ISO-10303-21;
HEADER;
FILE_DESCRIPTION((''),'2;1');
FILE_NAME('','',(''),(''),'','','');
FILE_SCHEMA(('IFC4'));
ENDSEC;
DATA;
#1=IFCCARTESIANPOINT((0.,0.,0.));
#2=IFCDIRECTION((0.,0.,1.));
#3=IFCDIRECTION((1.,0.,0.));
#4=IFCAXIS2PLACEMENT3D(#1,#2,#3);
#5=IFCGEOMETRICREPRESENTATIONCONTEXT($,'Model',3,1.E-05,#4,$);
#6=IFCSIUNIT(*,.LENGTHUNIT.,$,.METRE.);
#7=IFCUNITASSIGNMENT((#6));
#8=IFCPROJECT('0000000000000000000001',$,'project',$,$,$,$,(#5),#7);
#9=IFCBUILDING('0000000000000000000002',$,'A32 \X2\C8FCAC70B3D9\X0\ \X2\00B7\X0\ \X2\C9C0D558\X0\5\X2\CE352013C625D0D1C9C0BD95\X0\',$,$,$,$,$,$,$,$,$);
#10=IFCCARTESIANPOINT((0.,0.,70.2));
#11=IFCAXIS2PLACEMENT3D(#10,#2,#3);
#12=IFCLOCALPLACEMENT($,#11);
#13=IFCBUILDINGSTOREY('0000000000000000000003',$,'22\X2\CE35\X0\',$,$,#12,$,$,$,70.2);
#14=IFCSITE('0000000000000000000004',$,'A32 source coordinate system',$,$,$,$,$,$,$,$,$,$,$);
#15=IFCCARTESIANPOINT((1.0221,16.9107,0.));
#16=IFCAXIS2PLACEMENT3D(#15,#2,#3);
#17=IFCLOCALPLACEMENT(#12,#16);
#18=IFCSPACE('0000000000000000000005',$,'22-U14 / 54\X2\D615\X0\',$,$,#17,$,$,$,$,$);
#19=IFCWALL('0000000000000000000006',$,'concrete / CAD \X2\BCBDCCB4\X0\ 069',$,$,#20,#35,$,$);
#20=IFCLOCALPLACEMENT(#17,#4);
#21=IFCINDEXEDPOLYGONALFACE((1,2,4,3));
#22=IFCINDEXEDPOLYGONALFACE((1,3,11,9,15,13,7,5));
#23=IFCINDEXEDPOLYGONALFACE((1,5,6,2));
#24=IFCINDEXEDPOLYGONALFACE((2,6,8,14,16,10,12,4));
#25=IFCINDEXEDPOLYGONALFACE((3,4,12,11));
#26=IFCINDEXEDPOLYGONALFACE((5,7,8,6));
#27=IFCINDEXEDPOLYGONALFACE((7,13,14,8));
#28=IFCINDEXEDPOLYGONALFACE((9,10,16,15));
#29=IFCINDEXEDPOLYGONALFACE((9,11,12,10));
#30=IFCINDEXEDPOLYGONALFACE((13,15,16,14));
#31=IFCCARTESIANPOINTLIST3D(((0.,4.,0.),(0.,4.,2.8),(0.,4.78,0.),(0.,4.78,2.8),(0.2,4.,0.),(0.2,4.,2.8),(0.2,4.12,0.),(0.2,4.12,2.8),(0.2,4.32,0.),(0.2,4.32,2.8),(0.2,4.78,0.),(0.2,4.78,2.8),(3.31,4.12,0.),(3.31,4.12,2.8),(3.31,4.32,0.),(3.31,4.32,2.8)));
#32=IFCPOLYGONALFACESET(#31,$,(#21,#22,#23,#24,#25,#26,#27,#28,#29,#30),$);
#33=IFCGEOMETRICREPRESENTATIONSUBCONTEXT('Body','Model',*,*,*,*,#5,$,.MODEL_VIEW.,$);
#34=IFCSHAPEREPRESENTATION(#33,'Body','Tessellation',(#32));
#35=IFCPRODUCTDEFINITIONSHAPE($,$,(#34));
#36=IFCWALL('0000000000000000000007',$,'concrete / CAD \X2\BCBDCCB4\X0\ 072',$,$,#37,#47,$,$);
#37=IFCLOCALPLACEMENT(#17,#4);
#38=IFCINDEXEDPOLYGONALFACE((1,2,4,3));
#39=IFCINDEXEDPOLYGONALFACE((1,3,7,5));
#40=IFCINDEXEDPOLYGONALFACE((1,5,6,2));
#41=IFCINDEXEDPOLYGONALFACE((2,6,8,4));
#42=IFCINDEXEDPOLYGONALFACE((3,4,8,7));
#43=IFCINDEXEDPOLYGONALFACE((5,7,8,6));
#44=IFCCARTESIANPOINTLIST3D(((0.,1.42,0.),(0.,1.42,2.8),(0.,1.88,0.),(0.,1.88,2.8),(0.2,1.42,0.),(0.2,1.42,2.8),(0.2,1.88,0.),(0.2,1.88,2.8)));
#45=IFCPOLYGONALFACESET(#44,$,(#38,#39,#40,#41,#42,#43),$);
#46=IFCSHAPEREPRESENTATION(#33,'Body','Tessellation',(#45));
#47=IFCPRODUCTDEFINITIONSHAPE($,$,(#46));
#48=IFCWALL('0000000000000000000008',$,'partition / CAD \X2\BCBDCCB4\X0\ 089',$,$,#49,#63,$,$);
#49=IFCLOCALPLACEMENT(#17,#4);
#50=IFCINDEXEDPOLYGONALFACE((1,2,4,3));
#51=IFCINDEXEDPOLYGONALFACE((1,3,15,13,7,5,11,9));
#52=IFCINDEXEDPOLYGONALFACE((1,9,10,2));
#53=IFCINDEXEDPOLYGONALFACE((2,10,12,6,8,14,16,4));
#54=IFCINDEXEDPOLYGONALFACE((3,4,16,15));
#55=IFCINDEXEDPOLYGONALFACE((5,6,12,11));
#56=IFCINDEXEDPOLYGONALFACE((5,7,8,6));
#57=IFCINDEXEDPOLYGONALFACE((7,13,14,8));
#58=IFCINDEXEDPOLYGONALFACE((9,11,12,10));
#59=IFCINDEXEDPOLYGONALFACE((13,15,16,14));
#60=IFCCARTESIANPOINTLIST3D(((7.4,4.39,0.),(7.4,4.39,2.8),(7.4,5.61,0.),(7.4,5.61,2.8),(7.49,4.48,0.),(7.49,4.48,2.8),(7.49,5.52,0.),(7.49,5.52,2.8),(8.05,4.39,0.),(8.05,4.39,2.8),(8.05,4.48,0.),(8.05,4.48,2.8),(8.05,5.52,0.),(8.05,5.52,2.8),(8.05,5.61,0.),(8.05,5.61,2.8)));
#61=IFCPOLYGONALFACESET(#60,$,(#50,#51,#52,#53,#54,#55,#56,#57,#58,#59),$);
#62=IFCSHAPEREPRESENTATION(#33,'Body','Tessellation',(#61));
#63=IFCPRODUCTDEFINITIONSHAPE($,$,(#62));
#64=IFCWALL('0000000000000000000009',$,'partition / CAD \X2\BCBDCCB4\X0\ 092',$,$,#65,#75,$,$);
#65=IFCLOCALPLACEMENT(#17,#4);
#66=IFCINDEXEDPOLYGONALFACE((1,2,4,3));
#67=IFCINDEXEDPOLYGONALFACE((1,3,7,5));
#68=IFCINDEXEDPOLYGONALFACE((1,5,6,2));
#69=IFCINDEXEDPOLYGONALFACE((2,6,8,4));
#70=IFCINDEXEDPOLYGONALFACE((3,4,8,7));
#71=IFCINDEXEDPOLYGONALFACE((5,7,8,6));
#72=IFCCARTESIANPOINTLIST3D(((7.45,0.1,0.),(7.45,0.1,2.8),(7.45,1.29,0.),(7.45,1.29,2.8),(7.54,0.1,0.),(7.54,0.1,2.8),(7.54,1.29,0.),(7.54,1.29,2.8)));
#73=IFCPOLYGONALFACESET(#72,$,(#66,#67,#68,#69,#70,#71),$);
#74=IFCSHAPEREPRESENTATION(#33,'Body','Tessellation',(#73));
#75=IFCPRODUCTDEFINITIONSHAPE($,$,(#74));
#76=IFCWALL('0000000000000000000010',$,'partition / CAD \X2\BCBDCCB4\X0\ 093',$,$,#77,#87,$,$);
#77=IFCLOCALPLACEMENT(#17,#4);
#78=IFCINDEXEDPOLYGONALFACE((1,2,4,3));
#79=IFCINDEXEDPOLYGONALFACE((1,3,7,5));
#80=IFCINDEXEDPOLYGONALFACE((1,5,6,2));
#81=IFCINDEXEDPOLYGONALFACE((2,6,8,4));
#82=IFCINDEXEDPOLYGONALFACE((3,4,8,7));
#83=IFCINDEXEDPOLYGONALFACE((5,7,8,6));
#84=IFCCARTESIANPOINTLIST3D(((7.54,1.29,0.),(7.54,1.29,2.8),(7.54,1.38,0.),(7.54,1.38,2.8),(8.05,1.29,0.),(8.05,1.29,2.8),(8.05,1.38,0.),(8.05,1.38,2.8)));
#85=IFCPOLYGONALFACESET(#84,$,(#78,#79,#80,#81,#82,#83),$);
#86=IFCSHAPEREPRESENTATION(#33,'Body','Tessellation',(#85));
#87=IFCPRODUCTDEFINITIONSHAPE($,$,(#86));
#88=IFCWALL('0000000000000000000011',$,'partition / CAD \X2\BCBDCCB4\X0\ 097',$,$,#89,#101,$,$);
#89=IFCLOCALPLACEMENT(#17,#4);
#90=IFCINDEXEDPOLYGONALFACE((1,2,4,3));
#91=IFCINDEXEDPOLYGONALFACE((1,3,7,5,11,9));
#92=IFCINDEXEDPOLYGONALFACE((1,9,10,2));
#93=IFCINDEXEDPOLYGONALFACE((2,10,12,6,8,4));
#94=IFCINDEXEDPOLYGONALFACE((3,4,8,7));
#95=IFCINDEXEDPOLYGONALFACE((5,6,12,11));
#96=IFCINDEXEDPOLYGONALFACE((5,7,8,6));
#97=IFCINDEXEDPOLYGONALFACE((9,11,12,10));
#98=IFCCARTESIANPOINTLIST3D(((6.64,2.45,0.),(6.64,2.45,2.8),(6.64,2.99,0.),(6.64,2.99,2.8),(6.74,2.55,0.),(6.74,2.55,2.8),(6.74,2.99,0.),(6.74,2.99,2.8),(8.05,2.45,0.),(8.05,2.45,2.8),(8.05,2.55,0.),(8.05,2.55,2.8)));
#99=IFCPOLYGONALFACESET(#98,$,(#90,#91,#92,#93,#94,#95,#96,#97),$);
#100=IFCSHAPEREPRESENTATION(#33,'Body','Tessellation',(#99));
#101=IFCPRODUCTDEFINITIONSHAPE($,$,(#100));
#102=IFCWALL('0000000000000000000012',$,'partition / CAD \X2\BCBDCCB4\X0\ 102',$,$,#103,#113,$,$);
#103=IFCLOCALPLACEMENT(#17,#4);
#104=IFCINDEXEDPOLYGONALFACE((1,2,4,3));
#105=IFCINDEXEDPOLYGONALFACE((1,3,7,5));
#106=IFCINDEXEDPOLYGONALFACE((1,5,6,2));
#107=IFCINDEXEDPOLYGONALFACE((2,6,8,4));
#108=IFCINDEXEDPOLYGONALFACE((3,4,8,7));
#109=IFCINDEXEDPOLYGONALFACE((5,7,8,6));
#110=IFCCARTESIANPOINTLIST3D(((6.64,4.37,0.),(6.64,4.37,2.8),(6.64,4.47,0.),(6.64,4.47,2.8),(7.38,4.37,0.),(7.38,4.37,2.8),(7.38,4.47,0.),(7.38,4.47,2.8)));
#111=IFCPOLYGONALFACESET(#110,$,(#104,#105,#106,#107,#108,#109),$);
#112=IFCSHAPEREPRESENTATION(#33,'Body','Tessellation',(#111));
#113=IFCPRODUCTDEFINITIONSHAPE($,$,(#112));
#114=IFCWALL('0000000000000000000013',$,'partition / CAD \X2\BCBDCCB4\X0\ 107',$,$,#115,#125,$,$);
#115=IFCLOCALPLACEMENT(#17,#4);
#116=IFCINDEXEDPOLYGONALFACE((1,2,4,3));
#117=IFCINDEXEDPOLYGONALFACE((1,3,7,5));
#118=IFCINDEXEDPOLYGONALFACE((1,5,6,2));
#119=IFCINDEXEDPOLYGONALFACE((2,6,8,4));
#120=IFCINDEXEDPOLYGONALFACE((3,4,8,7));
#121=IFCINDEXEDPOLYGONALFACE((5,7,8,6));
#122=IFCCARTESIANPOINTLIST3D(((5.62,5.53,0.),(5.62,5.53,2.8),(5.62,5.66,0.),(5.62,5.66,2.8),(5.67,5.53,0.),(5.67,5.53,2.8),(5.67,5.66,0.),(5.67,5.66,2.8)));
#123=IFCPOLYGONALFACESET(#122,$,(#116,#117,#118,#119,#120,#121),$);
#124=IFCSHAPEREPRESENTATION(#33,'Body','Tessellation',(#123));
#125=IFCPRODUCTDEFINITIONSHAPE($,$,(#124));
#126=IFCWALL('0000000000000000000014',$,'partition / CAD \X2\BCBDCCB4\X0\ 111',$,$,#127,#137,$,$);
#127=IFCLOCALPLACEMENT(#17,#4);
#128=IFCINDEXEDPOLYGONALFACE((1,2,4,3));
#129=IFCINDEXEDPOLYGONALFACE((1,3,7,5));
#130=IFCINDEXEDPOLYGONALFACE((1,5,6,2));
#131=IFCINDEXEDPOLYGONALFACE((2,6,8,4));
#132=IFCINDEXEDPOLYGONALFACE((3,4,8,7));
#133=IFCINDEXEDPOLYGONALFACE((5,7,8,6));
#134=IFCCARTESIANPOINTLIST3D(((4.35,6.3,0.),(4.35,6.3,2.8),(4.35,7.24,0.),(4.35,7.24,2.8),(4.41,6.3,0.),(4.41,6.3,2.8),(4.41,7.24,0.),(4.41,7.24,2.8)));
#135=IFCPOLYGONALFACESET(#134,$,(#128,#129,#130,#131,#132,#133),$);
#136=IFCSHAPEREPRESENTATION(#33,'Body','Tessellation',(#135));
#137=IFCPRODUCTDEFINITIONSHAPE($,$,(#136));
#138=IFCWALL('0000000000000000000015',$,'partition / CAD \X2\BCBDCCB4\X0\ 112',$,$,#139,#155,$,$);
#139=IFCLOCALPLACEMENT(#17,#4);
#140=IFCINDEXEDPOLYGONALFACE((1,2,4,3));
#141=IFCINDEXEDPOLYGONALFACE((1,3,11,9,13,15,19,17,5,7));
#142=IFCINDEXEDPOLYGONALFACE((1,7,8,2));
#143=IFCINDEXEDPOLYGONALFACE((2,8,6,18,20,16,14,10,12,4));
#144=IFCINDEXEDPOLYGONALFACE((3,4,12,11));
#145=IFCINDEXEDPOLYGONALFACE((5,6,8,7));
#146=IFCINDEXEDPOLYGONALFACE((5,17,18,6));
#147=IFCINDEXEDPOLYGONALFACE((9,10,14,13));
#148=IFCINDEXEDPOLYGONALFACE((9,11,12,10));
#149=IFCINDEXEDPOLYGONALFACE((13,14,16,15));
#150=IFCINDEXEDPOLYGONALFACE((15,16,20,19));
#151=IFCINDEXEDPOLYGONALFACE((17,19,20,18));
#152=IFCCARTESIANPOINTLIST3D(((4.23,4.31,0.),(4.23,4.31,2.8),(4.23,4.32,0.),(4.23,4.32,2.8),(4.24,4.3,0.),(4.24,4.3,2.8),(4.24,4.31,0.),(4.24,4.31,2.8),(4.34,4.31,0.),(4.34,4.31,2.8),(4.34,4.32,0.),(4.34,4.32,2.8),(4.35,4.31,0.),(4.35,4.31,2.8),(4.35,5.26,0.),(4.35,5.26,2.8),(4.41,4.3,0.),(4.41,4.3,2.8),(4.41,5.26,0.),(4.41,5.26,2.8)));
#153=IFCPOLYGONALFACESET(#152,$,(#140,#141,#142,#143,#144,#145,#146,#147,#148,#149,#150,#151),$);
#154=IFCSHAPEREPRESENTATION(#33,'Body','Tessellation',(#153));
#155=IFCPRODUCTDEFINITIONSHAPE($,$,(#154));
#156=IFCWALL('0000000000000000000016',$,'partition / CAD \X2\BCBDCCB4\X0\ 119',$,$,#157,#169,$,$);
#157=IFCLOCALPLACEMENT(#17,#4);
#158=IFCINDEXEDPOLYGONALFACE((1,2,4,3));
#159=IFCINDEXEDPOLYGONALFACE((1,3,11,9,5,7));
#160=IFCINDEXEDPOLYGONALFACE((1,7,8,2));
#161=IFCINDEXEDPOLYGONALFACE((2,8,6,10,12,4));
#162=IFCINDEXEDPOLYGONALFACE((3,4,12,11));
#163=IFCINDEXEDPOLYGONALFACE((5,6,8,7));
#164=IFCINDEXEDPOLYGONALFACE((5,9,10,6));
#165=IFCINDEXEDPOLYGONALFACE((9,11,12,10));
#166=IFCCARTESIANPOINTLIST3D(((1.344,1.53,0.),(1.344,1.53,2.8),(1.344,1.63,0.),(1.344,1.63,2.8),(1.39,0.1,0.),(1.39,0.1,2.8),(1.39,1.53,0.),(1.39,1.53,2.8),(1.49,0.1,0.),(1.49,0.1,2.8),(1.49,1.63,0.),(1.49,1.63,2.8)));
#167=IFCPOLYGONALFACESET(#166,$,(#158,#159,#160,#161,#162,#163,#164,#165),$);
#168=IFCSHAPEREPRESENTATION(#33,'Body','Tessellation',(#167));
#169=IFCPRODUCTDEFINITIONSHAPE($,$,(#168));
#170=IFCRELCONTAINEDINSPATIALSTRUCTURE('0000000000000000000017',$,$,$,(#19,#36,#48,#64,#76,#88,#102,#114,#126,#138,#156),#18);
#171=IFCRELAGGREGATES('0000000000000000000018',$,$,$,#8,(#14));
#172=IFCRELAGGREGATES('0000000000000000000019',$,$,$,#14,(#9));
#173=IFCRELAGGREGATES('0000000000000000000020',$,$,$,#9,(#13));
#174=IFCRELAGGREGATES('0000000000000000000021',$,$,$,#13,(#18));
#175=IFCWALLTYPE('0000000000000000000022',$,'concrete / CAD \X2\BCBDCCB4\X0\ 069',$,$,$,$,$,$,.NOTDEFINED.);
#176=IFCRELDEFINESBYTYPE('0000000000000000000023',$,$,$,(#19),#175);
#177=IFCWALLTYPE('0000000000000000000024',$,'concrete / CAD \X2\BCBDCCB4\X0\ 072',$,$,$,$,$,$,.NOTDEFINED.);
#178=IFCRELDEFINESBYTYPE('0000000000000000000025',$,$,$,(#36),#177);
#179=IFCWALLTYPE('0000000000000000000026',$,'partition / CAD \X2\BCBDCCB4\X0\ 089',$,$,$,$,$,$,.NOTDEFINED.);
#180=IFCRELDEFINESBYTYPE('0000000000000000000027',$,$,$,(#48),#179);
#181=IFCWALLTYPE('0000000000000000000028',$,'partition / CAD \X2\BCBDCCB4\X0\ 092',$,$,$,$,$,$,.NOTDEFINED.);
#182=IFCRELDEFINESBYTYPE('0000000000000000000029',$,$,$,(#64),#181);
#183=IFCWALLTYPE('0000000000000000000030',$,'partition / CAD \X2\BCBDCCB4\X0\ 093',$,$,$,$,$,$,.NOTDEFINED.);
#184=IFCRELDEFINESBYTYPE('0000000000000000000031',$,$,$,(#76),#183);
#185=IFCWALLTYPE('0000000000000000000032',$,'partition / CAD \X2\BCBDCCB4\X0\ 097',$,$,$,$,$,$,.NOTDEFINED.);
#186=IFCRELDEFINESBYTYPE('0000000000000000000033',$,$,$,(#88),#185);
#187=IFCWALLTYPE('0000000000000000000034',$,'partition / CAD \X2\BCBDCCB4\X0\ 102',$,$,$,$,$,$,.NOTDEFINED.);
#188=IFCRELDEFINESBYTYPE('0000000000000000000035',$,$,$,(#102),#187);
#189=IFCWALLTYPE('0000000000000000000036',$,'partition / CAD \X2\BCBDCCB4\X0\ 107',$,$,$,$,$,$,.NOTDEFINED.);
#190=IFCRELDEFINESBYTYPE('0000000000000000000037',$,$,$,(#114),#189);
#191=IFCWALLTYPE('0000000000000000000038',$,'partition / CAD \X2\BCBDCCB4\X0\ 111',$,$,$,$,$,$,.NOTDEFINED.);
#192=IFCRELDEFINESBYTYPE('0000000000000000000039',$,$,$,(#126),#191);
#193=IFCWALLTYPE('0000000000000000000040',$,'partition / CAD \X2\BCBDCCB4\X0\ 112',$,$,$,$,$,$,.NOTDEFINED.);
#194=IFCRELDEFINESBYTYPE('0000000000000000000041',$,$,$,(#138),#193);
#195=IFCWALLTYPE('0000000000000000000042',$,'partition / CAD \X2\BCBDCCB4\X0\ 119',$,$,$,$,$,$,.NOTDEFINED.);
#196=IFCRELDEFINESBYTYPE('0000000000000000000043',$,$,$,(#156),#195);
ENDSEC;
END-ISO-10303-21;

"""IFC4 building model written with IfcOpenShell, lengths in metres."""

from ifc_helpers import new_model, si_unit, frame, origin, origin_with_axes, place, context, subcontext, project, spatial, polyline, outline, extrude, source, transform, mapped, type_object, type_shapes, element, save


model = new_model("IFC4")

# Units and contexts
model_context = context("Model", 3, precision=1e-05, world=origin_with_axes())
body_context = subcontext(model_context, "Body", "Model", "MODEL_VIEW")
ifc_project = project(units=[si_unit("LENGTHUNIT", "METRE")], contexts=[model_context])

# Site, building, storey, space
site = spatial("IfcSite", under=ifc_project, Name="A32 source coordinate system")
building = spatial("IfcBuilding", under=site, Name="A32 주거동 · 지하5층–옥탑지붕")
storey_placement = place(None, frame((0.0, 0.0, 70.2), z_axis=(0.0, 0.0, 1.0), x_axis=(1.0, 0.0, 0.0)))
storey = spatial("IfcBuildingStorey", under=building, at=storey_placement, Name="22층", Elevation=70.2)
space_placement = place(storey_placement, frame((1.0221, 16.9107, 0.0), z_axis=(0.0, 0.0, 1.0), x_axis=(1.0, 0.0, 0.0)))
space = spatial("IfcSpace", under=storey, at=space_placement, Name="22-U14 / 54형")

# Walls
wall_type_1 = type_object("IfcWallType", Name="concrete / CAD 벽체 069", PredefinedType="NOTDEFINED")
shared_shape_1 = source(origin(), body_context, "Body", "SweptSolid", [
    extrude(outline(polyline([(0.2, 4.12), (0.2, 4.0), (0.0, 4.0), (0.0, 4.78), (0.2, 4.78), (0.2, 4.32), (3.31, 4.32), (3.31, 4.12), (0.2, 4.12)])), origin(), (0.0, 0.0, 1.0), 2.8),
])
type_shapes(wall_type_1, [shared_shape_1])
wall_1_placement = place(space_placement, origin_with_axes())
element("IfcWall", 1, at=wall_1_placement, inside=space, type_object=wall_type_1, Name="concrete / CAD 벽체 069", context=body_context, shape_type="MappedRepresentation", body=[
    mapped(shared_shape_1, transform((0.0, 0.0, 0.0), scale=1.0)),
])
wall_type_2 = type_object("IfcWallType", Name="concrete / CAD 벽체 072", PredefinedType="NOTDEFINED")
shared_shape_2 = source(origin(), body_context, "Body", "SweptSolid", [
    extrude(outline(polyline([(0.2, 1.88), (0.2, 1.42), (0.0, 1.42), (0.0, 1.88), (0.2, 1.88)])), origin(), (0.0, 0.0, 1.0), 2.8),
])
type_shapes(wall_type_2, [shared_shape_2])
wall_2_placement = place(space_placement, origin_with_axes())
element("IfcWall", 2, at=wall_2_placement, inside=space, type_object=wall_type_2, Name="concrete / CAD 벽체 072", context=body_context, shape_type="MappedRepresentation", body=[
    mapped(shared_shape_2, transform((0.0, 0.0, 0.0), scale=1.0)),
])
wall_type_3 = type_object("IfcWallType", Name="partition / CAD 벽체 089", PredefinedType="NOTDEFINED")
shared_shape_3 = source(origin(), body_context, "Body", "SweptSolid", [
    extrude(outline(polyline([(7.49, 4.48), (8.05, 4.48), (8.05, 4.39), (7.4, 4.39), (7.4, 5.61), (8.05, 5.61), (8.05, 5.52), (7.49, 5.52), (7.49, 4.48)])), origin(), (0.0, 0.0, 1.0), 2.8),
])
type_shapes(wall_type_3, [shared_shape_3])
wall_3_placement = place(space_placement, origin_with_axes())
element("IfcWall", 3, at=wall_3_placement, inside=space, type_object=wall_type_3, Name="partition / CAD 벽체 089", context=body_context, shape_type="MappedRepresentation", body=[
    mapped(shared_shape_3, transform((0.0, 0.0, 0.0), scale=1.0)),
])
wall_type_4 = type_object("IfcWallType", Name="partition / CAD 벽체 092", PredefinedType="NOTDEFINED")
shared_shape_4 = source(origin(), body_context, "Body", "SweptSolid", [
    extrude(outline(polyline([(7.54, 1.29), (7.54, 0.1), (7.45, 0.1), (7.45, 1.29), (7.54, 1.29)])), origin(), (0.0, 0.0, 1.0), 2.8),
])
type_shapes(wall_type_4, [shared_shape_4])
wall_4_placement = place(space_placement, origin_with_axes())
element("IfcWall", 4, at=wall_4_placement, inside=space, type_object=wall_type_4, Name="partition / CAD 벽체 092", context=body_context, shape_type="MappedRepresentation", body=[
    mapped(shared_shape_4, transform((0.0, 0.0, 0.0), scale=1.0)),
])
wall_type_5 = type_object("IfcWallType", Name="partition / CAD 벽체 093", PredefinedType="NOTDEFINED")
shared_shape_5 = source(origin(), body_context, "Body", "SweptSolid", [
    extrude(outline(polyline([(8.05, 1.29), (7.54, 1.29), (7.54, 1.38), (8.05, 1.38), (8.05, 1.29)])), origin(), (0.0, 0.0, 1.0), 2.8),
])
type_shapes(wall_type_5, [shared_shape_5])
wall_5_placement = place(space_placement, origin_with_axes())
element("IfcWall", 5, at=wall_5_placement, inside=space, type_object=wall_type_5, Name="partition / CAD 벽체 093", context=body_context, shape_type="MappedRepresentation", body=[
    mapped(shared_shape_5, transform((0.0, 0.0, 0.0), scale=1.0)),
])
wall_type_6 = type_object("IfcWallType", Name="partition / CAD 벽체 097", PredefinedType="NOTDEFINED")
shared_shape_6 = source(origin(), body_context, "Body", "SweptSolid", [
    extrude(outline(polyline([(8.05, 2.45), (6.64, 2.45), (6.64, 2.99), (6.74, 2.99), (6.74, 2.55), (8.05, 2.55), (8.05, 2.45)])), origin(), (0.0, 0.0, 1.0), 2.8),
])
type_shapes(wall_type_6, [shared_shape_6])
wall_6_placement = place(space_placement, origin_with_axes())
element("IfcWall", 6, at=wall_6_placement, inside=space, type_object=wall_type_6, Name="partition / CAD 벽체 097", context=body_context, shape_type="MappedRepresentation", body=[
    mapped(shared_shape_6, transform((0.0, 0.0, 0.0), scale=1.0)),
])
wall_type_7 = type_object("IfcWallType", Name="partition / CAD 벽체 102", PredefinedType="NOTDEFINED")
shared_shape_7 = source(origin(), body_context, "Body", "SweptSolid", [
    extrude(outline(polyline([(7.38, 4.47), (7.38, 4.37), (6.64, 4.37), (6.64, 4.47), (7.38, 4.47)])), origin(), (0.0, 0.0, 1.0), 2.8),
])
type_shapes(wall_type_7, [shared_shape_7])
wall_7_placement = place(space_placement, origin_with_axes())
element("IfcWall", 7, at=wall_7_placement, inside=space, type_object=wall_type_7, Name="partition / CAD 벽체 102", context=body_context, shape_type="MappedRepresentation", body=[
    mapped(shared_shape_7, transform((0.0, 0.0, 0.0), scale=1.0)),
])
wall_type_8 = type_object("IfcWallType", Name="partition / CAD 벽체 107", PredefinedType="NOTDEFINED")
shared_shape_8 = source(origin(), body_context, "Body", "SweptSolid", [
    extrude(outline(polyline([(5.62, 5.53), (5.62, 5.66), (5.67, 5.66), (5.67, 5.53), (5.62, 5.53)])), origin(), (0.0, 0.0, 1.0), 2.8),
])
type_shapes(wall_type_8, [shared_shape_8])
wall_8_placement = place(space_placement, origin_with_axes())
element("IfcWall", 8, at=wall_8_placement, inside=space, type_object=wall_type_8, Name="partition / CAD 벽체 107", context=body_context, shape_type="MappedRepresentation", body=[
    mapped(shared_shape_8, transform((0.0, 0.0, 0.0), scale=1.0)),
])
wall_type_9 = type_object("IfcWallType", Name="partition / CAD 벽체 111", PredefinedType="NOTDEFINED")
shared_shape_9 = source(origin(), body_context, "Body", "SweptSolid", [
    extrude(outline(polyline([(4.41, 7.24), (4.41, 6.3), (4.35, 6.3), (4.35, 7.24), (4.41, 7.24)])), origin(), (0.0, 0.0, 1.0), 2.8),
])
type_shapes(wall_type_9, [shared_shape_9])
wall_9_placement = place(space_placement, origin_with_axes())
element("IfcWall", 9, at=wall_9_placement, inside=space, type_object=wall_type_9, Name="partition / CAD 벽체 111", context=body_context, shape_type="MappedRepresentation", body=[
    mapped(shared_shape_9, transform((0.0, 0.0, 0.0), scale=1.0)),
])
wall_type_10 = type_object("IfcWallType", Name="partition / CAD 벽체 112", PredefinedType="NOTDEFINED")
shared_shape_10 = source(origin(), body_context, "Body", "SweptSolid", [
    extrude(outline(polyline([(4.24, 4.3), (4.24, 4.31), (4.23, 4.31), (4.23, 4.32), (4.34, 4.32), (4.34, 4.31), (4.35, 4.31), (4.35, 5.26), (4.41, 5.26), (4.41, 4.3), (4.24, 4.3)])), origin(), (0.0, 0.0, 1.0), 2.8),
])
type_shapes(wall_type_10, [shared_shape_10])
wall_10_placement = place(space_placement, origin_with_axes())
element("IfcWall", 10, at=wall_10_placement, inside=space, type_object=wall_type_10, Name="partition / CAD 벽체 112", context=body_context, shape_type="MappedRepresentation", body=[
    mapped(shared_shape_10, transform((0.0, 0.0, 0.0), scale=1.0)),
])
wall_type_11 = type_object("IfcWallType", Name="partition / CAD 벽체 119", PredefinedType="NOTDEFINED")
shared_shape_11 = source(origin(), body_context, "Body", "SweptSolid", [
    extrude(outline(polyline([(1.344, 1.53), (1.344, 1.63), (1.49, 1.63), (1.49, 0.1), (1.39, 0.1), (1.39, 1.53), (1.344, 1.53)])), origin(), (0.0, 0.0, 1.0), 2.8),
])
type_shapes(wall_type_11, [shared_shape_11])
wall_11_placement = place(space_placement, origin_with_axes())
element("IfcWall", 11, at=wall_11_placement, inside=space, type_object=wall_type_11, Name="partition / CAD 벽체 119", context=body_context, shape_type="MappedRepresentation", body=[
    mapped(shared_shape_11, transform((0.0, 0.0, 0.0), scale=1.0)),
])

save(model, "model.ifc")
